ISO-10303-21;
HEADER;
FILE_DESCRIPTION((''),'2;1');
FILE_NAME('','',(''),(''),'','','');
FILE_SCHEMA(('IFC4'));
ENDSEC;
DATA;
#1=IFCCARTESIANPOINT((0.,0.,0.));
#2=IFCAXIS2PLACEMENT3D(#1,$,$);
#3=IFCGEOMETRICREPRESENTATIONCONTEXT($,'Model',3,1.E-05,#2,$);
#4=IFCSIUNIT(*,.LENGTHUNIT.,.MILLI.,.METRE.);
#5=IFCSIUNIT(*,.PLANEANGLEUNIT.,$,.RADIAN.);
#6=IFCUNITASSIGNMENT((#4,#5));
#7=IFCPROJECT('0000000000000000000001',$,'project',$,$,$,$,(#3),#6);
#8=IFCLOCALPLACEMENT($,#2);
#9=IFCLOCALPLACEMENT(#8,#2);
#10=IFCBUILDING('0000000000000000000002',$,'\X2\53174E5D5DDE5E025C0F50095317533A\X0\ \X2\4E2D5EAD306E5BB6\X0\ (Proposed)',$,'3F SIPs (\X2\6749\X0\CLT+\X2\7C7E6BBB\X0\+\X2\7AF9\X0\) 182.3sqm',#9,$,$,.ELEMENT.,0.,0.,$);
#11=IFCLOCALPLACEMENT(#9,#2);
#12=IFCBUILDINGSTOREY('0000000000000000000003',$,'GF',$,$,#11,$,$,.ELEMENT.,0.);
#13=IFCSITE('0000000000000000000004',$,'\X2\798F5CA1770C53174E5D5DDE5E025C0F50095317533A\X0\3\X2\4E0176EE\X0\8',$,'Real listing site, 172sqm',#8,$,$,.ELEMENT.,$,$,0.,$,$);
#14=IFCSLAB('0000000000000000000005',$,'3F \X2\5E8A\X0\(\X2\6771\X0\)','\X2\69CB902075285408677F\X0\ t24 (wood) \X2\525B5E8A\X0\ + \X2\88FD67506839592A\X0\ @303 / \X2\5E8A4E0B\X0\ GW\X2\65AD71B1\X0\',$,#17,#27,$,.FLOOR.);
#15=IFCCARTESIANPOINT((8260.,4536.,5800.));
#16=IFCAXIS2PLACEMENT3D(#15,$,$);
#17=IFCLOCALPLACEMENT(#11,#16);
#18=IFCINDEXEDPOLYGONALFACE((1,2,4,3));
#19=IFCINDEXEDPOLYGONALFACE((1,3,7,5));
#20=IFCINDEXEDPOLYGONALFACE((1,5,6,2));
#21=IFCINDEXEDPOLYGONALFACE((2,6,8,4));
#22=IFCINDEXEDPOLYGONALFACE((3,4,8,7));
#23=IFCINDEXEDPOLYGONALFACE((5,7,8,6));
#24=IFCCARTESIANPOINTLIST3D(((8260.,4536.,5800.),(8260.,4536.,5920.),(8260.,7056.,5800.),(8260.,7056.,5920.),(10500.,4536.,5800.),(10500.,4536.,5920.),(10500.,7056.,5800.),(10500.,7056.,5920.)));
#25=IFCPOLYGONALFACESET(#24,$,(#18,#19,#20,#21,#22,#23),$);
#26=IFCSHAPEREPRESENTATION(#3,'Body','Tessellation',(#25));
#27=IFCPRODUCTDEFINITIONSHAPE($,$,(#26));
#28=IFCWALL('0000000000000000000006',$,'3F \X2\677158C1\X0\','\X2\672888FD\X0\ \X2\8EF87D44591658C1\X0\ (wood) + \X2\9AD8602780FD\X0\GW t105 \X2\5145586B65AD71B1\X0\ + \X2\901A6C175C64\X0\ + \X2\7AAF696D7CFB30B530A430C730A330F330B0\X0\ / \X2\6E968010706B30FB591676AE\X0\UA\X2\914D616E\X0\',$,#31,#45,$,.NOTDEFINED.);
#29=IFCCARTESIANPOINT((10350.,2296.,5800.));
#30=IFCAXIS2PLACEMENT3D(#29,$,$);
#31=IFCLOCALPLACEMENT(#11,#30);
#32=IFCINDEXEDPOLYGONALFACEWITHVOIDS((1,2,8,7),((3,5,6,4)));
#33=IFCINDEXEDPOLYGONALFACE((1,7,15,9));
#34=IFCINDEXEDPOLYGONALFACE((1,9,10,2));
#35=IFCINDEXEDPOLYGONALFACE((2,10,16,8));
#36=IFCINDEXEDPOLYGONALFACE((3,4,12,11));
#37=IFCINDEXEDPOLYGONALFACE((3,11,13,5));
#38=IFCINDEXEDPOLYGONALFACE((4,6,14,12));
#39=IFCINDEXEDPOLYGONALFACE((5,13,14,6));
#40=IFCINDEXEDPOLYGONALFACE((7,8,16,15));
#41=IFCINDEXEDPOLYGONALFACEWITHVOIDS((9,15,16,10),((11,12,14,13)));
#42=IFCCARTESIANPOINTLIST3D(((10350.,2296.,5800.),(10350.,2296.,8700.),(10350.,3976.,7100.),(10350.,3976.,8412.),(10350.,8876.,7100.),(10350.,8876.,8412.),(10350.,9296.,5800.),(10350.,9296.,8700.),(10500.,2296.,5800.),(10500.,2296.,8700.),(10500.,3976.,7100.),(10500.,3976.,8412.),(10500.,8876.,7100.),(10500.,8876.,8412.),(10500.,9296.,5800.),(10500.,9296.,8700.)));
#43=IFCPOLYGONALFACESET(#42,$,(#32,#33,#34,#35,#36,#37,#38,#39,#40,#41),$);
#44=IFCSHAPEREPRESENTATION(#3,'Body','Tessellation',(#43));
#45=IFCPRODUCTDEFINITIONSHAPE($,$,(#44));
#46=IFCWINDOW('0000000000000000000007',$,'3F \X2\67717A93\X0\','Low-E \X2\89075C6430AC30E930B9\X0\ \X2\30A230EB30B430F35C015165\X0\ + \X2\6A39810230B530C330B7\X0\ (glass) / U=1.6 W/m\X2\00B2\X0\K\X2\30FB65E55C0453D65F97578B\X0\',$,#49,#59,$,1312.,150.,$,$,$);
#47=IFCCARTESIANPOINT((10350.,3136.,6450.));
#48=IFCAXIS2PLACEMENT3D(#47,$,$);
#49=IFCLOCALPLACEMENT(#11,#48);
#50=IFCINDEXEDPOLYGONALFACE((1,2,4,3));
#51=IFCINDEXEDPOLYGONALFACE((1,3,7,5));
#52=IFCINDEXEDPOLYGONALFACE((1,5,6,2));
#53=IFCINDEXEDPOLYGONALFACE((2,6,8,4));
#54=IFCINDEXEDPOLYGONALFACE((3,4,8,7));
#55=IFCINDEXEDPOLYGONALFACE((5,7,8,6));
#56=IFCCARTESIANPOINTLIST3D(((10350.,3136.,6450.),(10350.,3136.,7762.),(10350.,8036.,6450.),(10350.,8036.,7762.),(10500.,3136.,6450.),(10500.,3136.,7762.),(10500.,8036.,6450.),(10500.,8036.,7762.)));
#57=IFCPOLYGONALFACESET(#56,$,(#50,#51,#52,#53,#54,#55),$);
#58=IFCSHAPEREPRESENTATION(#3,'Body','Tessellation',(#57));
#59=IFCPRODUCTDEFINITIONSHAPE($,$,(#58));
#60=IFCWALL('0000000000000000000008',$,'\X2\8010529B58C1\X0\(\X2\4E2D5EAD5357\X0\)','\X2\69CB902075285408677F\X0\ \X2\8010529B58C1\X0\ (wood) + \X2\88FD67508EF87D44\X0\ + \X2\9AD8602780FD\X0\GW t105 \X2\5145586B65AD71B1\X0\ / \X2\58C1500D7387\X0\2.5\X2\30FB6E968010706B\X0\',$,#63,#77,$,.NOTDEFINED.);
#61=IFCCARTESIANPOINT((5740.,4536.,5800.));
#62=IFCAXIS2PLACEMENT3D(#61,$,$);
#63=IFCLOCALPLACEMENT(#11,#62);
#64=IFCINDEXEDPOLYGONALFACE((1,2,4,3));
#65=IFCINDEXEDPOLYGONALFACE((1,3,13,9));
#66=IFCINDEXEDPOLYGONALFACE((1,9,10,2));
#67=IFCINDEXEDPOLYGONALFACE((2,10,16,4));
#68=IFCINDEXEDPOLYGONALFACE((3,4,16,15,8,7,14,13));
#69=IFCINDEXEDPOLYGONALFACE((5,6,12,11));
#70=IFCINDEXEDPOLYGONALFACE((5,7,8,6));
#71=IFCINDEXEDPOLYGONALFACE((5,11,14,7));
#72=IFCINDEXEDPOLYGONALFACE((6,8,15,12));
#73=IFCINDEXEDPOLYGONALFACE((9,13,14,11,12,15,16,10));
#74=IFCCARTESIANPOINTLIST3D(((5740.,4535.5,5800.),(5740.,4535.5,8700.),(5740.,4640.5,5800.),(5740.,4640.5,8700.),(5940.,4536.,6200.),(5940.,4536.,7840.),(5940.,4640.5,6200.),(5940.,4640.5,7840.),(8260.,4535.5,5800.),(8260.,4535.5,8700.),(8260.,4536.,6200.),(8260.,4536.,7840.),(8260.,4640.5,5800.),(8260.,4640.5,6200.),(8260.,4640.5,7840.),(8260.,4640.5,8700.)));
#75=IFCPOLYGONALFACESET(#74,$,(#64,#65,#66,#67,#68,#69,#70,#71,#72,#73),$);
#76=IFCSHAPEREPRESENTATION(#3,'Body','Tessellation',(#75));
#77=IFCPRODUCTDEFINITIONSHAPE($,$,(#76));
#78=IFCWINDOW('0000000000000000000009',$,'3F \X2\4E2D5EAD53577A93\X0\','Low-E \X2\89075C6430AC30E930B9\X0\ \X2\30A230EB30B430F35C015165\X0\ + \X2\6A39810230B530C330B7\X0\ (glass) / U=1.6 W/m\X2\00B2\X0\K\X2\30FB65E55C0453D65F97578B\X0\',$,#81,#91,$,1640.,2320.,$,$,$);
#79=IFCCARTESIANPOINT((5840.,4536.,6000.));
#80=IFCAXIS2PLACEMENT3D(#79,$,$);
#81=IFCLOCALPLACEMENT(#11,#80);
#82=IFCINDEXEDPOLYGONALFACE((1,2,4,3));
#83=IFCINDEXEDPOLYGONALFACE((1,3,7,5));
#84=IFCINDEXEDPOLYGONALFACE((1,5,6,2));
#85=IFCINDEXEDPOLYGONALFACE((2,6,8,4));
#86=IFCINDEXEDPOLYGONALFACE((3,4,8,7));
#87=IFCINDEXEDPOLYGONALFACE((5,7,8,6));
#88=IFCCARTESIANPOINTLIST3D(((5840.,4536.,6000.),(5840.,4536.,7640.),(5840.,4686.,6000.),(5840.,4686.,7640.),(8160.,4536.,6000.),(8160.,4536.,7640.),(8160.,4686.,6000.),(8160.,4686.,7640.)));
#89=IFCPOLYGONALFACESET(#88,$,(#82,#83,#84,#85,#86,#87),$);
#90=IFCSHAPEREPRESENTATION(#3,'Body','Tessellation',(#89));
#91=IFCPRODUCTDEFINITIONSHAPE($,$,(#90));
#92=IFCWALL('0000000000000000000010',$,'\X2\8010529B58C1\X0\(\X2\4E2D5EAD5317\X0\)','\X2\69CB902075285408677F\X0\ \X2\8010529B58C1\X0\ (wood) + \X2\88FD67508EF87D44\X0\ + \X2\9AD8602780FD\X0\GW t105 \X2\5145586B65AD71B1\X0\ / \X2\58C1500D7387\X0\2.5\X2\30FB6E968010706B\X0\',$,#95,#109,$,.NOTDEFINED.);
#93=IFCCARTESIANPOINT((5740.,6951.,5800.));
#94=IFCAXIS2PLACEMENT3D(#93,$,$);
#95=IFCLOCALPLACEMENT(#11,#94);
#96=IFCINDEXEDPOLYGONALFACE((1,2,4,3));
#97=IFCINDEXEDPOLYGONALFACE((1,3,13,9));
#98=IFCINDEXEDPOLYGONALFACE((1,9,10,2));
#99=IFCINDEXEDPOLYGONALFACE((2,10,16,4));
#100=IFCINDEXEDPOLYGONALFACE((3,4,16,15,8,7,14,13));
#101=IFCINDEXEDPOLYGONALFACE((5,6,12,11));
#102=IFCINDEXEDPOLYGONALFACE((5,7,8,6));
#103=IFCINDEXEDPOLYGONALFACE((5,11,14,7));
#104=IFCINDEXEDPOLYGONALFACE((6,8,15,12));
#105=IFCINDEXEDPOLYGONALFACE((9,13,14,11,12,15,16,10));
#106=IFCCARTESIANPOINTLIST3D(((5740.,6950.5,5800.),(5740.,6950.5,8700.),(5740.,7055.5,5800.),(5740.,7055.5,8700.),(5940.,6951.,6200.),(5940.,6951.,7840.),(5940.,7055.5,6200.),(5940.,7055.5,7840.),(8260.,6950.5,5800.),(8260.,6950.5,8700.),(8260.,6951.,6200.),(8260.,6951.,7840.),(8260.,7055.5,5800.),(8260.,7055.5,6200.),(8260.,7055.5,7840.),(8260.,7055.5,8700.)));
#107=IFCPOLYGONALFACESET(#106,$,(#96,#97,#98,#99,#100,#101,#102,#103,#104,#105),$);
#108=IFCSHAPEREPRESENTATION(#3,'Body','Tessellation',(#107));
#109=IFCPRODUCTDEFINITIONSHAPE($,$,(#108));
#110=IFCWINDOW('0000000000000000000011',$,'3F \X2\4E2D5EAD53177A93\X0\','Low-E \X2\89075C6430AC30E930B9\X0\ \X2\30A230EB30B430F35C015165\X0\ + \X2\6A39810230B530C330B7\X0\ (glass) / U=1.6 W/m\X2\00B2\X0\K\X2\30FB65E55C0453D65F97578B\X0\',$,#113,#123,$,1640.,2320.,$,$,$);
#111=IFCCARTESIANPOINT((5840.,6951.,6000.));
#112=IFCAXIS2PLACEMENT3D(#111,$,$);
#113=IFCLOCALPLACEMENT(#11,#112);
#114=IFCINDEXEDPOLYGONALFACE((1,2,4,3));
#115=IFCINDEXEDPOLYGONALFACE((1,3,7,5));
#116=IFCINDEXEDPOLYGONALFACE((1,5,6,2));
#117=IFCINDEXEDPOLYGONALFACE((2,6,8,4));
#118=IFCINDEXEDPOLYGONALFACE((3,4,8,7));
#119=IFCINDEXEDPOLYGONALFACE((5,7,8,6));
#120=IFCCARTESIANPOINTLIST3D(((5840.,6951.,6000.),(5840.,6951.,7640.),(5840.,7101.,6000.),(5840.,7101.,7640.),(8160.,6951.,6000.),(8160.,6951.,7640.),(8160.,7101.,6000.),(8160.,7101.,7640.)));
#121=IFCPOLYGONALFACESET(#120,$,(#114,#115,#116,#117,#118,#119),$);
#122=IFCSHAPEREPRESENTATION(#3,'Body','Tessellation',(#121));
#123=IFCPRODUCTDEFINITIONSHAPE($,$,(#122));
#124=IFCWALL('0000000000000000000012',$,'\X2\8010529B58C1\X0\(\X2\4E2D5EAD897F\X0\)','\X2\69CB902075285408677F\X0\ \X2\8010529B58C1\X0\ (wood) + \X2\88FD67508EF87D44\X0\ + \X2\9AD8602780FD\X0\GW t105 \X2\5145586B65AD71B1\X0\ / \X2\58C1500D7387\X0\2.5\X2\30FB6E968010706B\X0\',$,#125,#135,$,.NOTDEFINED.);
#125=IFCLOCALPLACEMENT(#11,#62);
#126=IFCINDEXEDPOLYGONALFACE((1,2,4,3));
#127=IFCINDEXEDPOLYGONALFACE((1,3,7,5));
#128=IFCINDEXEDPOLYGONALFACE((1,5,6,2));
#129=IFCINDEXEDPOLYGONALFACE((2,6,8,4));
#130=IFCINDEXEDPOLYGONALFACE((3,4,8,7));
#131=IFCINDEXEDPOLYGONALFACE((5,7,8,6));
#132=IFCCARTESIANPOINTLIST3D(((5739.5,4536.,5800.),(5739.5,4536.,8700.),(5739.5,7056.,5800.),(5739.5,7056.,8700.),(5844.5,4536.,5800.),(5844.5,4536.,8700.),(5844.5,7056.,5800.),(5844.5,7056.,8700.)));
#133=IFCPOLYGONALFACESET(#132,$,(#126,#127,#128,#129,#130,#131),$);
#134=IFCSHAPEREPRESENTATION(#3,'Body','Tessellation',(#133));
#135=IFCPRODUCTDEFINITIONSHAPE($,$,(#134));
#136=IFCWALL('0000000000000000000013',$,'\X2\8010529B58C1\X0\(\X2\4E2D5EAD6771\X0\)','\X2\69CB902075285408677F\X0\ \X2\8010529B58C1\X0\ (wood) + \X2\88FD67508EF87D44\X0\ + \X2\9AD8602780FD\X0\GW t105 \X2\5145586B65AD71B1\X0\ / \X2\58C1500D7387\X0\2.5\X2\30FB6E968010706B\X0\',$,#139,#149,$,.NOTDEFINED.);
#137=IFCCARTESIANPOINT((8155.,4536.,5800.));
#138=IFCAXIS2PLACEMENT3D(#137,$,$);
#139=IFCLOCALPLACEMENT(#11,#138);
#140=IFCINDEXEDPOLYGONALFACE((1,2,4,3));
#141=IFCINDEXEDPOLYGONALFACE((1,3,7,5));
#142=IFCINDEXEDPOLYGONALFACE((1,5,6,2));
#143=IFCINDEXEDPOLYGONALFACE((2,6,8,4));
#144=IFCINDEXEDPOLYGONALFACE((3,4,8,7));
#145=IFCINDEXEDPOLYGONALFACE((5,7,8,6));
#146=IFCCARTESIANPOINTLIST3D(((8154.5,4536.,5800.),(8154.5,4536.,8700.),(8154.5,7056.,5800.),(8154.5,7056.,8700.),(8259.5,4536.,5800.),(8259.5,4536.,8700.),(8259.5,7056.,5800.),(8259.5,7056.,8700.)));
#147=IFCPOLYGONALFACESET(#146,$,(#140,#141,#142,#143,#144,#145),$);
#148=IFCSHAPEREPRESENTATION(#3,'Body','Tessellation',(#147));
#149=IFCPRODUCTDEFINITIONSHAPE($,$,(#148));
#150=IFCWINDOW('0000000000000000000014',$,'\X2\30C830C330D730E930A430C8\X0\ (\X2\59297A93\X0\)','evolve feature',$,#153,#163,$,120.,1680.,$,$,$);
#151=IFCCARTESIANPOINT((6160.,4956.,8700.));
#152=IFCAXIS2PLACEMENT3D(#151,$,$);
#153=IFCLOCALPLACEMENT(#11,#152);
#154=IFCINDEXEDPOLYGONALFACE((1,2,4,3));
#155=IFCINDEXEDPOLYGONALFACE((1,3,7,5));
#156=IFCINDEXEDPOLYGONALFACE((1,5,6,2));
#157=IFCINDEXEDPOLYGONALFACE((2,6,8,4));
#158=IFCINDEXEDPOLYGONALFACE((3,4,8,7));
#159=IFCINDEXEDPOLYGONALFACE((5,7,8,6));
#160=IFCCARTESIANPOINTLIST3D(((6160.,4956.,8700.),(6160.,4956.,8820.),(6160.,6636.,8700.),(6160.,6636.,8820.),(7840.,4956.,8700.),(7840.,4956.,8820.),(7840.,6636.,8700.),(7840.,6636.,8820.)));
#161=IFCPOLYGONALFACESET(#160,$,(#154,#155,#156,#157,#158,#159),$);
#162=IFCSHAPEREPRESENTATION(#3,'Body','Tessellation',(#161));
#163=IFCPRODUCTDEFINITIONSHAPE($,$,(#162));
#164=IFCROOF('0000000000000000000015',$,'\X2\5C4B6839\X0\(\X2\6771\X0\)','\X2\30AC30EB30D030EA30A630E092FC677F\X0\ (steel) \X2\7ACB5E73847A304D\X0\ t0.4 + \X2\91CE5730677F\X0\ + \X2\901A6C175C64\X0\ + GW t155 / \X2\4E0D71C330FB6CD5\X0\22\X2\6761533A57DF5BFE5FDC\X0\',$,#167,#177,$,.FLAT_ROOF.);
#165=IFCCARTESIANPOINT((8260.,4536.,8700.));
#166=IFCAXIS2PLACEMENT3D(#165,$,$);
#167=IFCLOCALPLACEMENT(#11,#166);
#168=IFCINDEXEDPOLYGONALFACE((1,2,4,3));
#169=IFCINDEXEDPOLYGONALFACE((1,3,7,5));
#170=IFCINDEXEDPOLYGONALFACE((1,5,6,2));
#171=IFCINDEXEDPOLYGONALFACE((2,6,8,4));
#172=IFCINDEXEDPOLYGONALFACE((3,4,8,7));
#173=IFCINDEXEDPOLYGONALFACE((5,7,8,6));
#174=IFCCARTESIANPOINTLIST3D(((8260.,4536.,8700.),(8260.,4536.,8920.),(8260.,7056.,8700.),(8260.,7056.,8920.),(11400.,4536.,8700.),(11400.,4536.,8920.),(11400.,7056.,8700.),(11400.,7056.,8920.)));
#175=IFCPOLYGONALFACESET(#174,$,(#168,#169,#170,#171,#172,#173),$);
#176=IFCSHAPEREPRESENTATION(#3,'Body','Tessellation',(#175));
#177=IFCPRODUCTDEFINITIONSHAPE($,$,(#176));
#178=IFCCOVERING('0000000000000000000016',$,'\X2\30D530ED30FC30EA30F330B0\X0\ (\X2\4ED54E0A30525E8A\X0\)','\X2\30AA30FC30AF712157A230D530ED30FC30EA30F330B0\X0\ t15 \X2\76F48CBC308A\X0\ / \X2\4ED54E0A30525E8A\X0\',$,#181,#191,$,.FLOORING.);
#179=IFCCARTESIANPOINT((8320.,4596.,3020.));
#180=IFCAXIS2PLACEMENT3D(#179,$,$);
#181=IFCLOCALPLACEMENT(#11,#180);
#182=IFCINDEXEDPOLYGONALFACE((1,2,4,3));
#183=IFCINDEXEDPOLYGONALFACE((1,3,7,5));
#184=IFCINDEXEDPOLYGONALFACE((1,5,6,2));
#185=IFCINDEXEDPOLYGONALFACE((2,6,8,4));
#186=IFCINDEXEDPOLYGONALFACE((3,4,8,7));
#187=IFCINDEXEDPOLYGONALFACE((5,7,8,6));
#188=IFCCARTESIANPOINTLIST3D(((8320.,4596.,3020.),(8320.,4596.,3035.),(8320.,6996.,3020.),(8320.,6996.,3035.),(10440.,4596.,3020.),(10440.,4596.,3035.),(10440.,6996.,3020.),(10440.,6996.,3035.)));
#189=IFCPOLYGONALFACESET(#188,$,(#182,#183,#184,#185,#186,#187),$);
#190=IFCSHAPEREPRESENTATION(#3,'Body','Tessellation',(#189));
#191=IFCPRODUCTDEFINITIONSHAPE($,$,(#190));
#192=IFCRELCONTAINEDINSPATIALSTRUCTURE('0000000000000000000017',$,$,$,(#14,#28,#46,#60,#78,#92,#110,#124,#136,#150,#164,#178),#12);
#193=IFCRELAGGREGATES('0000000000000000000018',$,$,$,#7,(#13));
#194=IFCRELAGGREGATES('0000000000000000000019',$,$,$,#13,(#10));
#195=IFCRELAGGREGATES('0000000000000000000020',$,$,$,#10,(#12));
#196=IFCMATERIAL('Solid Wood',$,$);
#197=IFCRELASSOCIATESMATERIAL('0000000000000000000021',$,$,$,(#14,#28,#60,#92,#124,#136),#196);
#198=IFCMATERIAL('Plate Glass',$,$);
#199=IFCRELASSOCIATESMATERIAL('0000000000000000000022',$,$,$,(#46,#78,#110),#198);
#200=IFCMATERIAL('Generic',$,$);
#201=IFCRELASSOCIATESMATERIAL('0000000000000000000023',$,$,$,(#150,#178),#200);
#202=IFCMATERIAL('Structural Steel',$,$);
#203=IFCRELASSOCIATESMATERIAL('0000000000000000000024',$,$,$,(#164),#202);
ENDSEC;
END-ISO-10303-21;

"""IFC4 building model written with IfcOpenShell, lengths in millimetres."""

from ifc_helpers import new_model, si_unit, frame, frame_2d, origin, place, context, project, spatial, rectangle, extrude, material, element, fill, save


model = new_model("IFC4")

# Units and contexts
model_context = context("Model", 3, precision=1e-05, world=origin())
ifc_project = project(units=[si_unit("LENGTHUNIT", "METRE", prefix="MILLI"), si_unit("PLANEANGLEUNIT", "RADIAN")], contexts=[model_context])

# Site, building, storey
site_placement = place(None, origin())
site = spatial("IfcSite", under=ifc_project, at=site_placement, Name="福岡県北九州市小倉北区3丁目8", ObjectType="Real listing site, 172sqm", CompositionType="ELEMENT", RefElevation=0.0)
building_placement = place(site_placement, origin())
building = spatial("IfcBuilding", under=site, at=building_placement, Name="北九州市小倉北区 中庭の家 (Proposed)", ObjectType="3F SIPs (杉CLT+籾殻+竹) 182.3sqm", CompositionType="ELEMENT", ElevationOfRefHeight=0.0, ElevationOfTerrain=0.0)
storey_placement = place(building_placement, origin())
storey = spatial("IfcBuildingStorey", under=building, at=storey_placement, Name="GF", CompositionType="ELEMENT", Elevation=0.0)

# Slab
ifc_material_1 = material(Name="Solid Wood")
slab_placement = place(storey_placement, frame((8260.0, 4536.0, 5800.0)))
element("IfcSlab", 1, at=slab_placement, inside=storey, material=ifc_material_1, Name="3F 床(東)", Description="構造用合板 t24 (wood) 剛床 + 製材根太 @303 / 床下 GW断熱", PredefinedType="FLOOR", context=model_context, shape_type="SweptSolid", body=[
    extrude(rectangle(XDim=2240.0, YDim=2520.0, at=frame_2d((1120.0, 1260.0))), frame((8260.0, 4536.0, 5800.0)), (0.0, 0.0, 1.0), 120.0),
])

# Walls, openings, windows
wall_1_placement = place(storey_placement, frame((10350.0, 2296.0, 5800.0)))
wall_1 = element("IfcWall", 2, at=wall_1_placement, inside=storey, material=ifc_material_1, Name="3F 東壁", Description="木製 軸組外壁 (wood) + 高性能GW t105 充填断熱 + 通気層 + 窯業系サイディング / 準耐火・外皮UA配慮", PredefinedType="NOTDEFINED", context=model_context, shape_type="SweptSolid", body=[
    extrude(rectangle(XDim=150.0, YDim=7000.0, at=frame_2d((75.0, 3500.0))), frame((10350.0, 2296.0, 5800.0)), (0.0, 0.0, 1.0), 2900.0),
])
opening_1_placement = place(storey_placement, frame((10350.0, 3136.0, 6450.0)))
opening_1 = element("IfcOpeningElement", 3, at=opening_1_placement, cuts=wall_1, PredefinedType="NOTDEFINED", context=model_context, shape_type="SweptSolid", body=[
    extrude(rectangle(XDim=150.0, YDim=4900.0, at=frame_2d((75.0, 2450.0))), frame((10350.0, 3136.0, 6450.0)), (0.0, 0.0, 1.0), 1312.0),
])
ifc_material_2 = material(Name="Plate Glass")
window_1_placement = place(storey_placement, frame((10350.0, 3136.0, 6450.0)))
window_1 = element("IfcWindow", 4, at=window_1_placement, inside=storey, material=ifc_material_2, Name="3F 東窓", Description="Low-E 複層ガラス アルゴン封入 + 樹脂サッシ (glass) / U=1.6 W/m²K・日射取得型", OverallHeight=1312.0, OverallWidth=150.0, context=model_context, shape_type="SweptSolid", body=[
    extrude(rectangle(XDim=150.0, YDim=4900.0, at=frame_2d((75.0, 2450.0))), frame((10350.0, 3136.0, 6450.0)), (0.0, 0.0, 1.0), 1312.0),
])
fill(opening_1, window_1)
wall_2_placement = place(storey_placement, frame((5740.0, 4536.0, 5800.0)))
wall_2 = element("IfcWall", 5, at=wall_2_placement, inside=storey, material=ifc_material_1, Name="耐力壁(中庭南)", Description="構造用合板 耐力壁 (wood) + 製材軸組 + 高性能GW t105 充填断熱 / 壁倍率2.5・準耐火", PredefinedType="NOTDEFINED", context=model_context, shape_type="SweptSolid", body=[
    extrude(rectangle(XDim=2520.0, YDim=105.0, at=frame_2d((1260.0, 52.0))), frame((5740.0, 4536.0, 5800.0)), (0.0, 0.0, 1.0), 2900.0),
])
opening_2_placement = place(storey_placement, frame((5840.0, 4536.0, 6000.0)))
opening_2 = element("IfcOpeningElement", 6, at=opening_2_placement, cuts=wall_2, PredefinedType="NOTDEFINED", context=model_context, shape_type="SweptSolid", body=[
    extrude(rectangle(XDim=2320.0, YDim=150.0, at=frame_2d((1160.0, 75.0))), frame((5840.0, 4536.0, 6000.0)), (0.0, 0.0, 1.0), 1640.0),
])
window_2_placement = place(storey_placement, frame((5840.0, 4536.0, 6000.0)))
window_2 = element("IfcWindow", 7, at=window_2_placement, inside=storey, material=ifc_material_2, Name="3F 中庭南窓", Description="Low-E 複層ガラス アルゴン封入 + 樹脂サッシ (glass) / U=1.6 W/m²K・日射取得型", OverallHeight=1640.0, OverallWidth=2320.0, context=model_context, shape_type="SweptSolid", body=[
    extrude(rectangle(XDim=2320.0, YDim=150.0, at=frame_2d((1160.0, 75.0))), frame((5840.0, 4536.0, 6000.0)), (0.0, 0.0, 1.0), 1640.0),
])
fill(opening_2, window_2)
wall_3_placement = place(storey_placement, frame((5740.0, 6951.0, 5800.0)))
wall_3 = element("IfcWall", 8, at=wall_3_placement, inside=storey, material=ifc_material_1, Name="耐力壁(中庭北)", Description="構造用合板 耐力壁 (wood) + 製材軸組 + 高性能GW t105 充填断熱 / 壁倍率2.5・準耐火", PredefinedType="NOTDEFINED", context=model_context, shape_type="SweptSolid", body=[
    extrude(rectangle(XDim=2520.0, YDim=105.0, at=frame_2d((1260.0, 52.0))), frame((5740.0, 6951.0, 5800.0)), (0.0, 0.0, 1.0), 2900.0),
])
opening_3_placement = place(storey_placement, frame((5840.0, 6951.0, 6000.0)))
opening_3 = element("IfcOpeningElement", 9, at=opening_3_placement, cuts=wall_3, PredefinedType="NOTDEFINED", context=model_context, shape_type="SweptSolid", body=[
    extrude(rectangle(XDim=2320.0, YDim=150.0, at=frame_2d((1160.0, 75.0))), frame((5840.0, 6951.0, 6000.0)), (0.0, 0.0, 1.0), 1640.0),
])
window_3_placement = place(storey_placement, frame((5840.0, 6951.0, 6000.0)))
window_3 = element("IfcWindow", 10, at=window_3_placement, inside=storey, material=ifc_material_2, Name="3F 中庭北窓", Description="Low-E 複層ガラス アルゴン封入 + 樹脂サッシ (glass) / U=1.6 W/m²K・日射取得型", OverallHeight=1640.0, OverallWidth=2320.0, context=model_context, shape_type="SweptSolid", body=[
    extrude(rectangle(XDim=2320.0, YDim=150.0, at=frame_2d((1160.0, 75.0))), frame((5840.0, 6951.0, 6000.0)), (0.0, 0.0, 1.0), 1640.0),
])
fill(opening_3, window_3)

# Walls
wall_4_placement = place(storey_placement, frame((5740.0, 4536.0, 5800.0)))
element("IfcWall", 11, at=wall_4_placement, inside=storey, material=ifc_material_1, Name="耐力壁(中庭西)", Description="構造用合板 耐力壁 (wood) + 製材軸組 + 高性能GW t105 充填断熱 / 壁倍率2.5・準耐火", PredefinedType="NOTDEFINED", context=model_context, shape_type="SweptSolid", body=[
    extrude(rectangle(XDim=105.0, YDim=2520.0, at=frame_2d((52.0, 1260.0))), frame((5740.0, 4536.0, 5800.0)), (0.0, 0.0, 1.0), 2900.0),
])
wall_5_placement = place(storey_placement, frame((8155.0, 4536.0, 5800.0)))
element("IfcWall", 12, at=wall_5_placement, inside=storey, material=ifc_material_1, Name="耐力壁(中庭東)", Description="構造用合板 耐力壁 (wood) + 製材軸組 + 高性能GW t105 充填断熱 / 壁倍率2.5・準耐火", PredefinedType="NOTDEFINED", context=model_context, shape_type="SweptSolid", body=[
    extrude(rectangle(XDim=105.0, YDim=2520.0, at=frame_2d((52.0, 1260.0))), frame((8155.0, 4536.0, 5800.0)), (0.0, 0.0, 1.0), 2900.0),
])

# Window
ifc_material_3 = material(Name="Generic")
window_4_placement = place(storey_placement, frame((6160.0, 4956.0, 8700.0)))
element("IfcWindow", 13, at=window_4_placement, inside=storey, material=ifc_material_3, Name="トップライト (天窓)", Description="evolve feature", OverallHeight=120.0, OverallWidth=1680.0, context=model_context, shape_type="SweptSolid", body=[
    extrude(rectangle(XDim=1680.0, YDim=1680.0, at=frame_2d((840.0, 840.0))), frame((6160.0, 4956.0, 8700.0)), (0.0, 0.0, 1.0), 120.0),
])

# Roof
ifc_material_4 = material(Name="Structural Steel")
for number, where, name in (
    (14, (8260.0, 4536.0, 8700.0), "屋根(東)"),
):
    element("IfcRoof", number, at=place(storey_placement, frame(where)), inside=storey, material=ifc_material_4, Name=name, Description="ガルバリウム鋼板 (steel) 立平葺き t0.4 + 野地板 + 通気層 + GW t155 / 不燃・法22条区域対応", PredefinedType="FLAT_ROOF", context=model_context, shape_type="SweptSolid", body=[
        extrude(rectangle(XDim=3140.0, YDim=2520.0, at=frame_2d((1570.0, 1260.0))), frame((8260.0, 4536.0, 8700.0)), (0.0, 0.0, 1.0), 220.0),
    ])

# Covering
covering_1_placement = place(storey_placement, frame((8320.0, 4596.0, 3020.0)))
element("IfcCovering", 15, at=covering_1_placement, inside=storey, material=ifc_material_3, Name="フローリング (仕上げ床)", Description="オーク無垢フローリング t15 直貼り / 仕上げ床", PredefinedType="FLOORING", context=model_context, shape_type="SweptSolid", body=[
    extrude(rectangle(XDim=2120.0, YDim=2400.0, at=frame_2d((1060.0, 1200.0))), frame((8320.0, 4596.0, 3020.0)), (0.0, 0.0, 1.0), 15.0),
])

save(model, "model.ifc")
